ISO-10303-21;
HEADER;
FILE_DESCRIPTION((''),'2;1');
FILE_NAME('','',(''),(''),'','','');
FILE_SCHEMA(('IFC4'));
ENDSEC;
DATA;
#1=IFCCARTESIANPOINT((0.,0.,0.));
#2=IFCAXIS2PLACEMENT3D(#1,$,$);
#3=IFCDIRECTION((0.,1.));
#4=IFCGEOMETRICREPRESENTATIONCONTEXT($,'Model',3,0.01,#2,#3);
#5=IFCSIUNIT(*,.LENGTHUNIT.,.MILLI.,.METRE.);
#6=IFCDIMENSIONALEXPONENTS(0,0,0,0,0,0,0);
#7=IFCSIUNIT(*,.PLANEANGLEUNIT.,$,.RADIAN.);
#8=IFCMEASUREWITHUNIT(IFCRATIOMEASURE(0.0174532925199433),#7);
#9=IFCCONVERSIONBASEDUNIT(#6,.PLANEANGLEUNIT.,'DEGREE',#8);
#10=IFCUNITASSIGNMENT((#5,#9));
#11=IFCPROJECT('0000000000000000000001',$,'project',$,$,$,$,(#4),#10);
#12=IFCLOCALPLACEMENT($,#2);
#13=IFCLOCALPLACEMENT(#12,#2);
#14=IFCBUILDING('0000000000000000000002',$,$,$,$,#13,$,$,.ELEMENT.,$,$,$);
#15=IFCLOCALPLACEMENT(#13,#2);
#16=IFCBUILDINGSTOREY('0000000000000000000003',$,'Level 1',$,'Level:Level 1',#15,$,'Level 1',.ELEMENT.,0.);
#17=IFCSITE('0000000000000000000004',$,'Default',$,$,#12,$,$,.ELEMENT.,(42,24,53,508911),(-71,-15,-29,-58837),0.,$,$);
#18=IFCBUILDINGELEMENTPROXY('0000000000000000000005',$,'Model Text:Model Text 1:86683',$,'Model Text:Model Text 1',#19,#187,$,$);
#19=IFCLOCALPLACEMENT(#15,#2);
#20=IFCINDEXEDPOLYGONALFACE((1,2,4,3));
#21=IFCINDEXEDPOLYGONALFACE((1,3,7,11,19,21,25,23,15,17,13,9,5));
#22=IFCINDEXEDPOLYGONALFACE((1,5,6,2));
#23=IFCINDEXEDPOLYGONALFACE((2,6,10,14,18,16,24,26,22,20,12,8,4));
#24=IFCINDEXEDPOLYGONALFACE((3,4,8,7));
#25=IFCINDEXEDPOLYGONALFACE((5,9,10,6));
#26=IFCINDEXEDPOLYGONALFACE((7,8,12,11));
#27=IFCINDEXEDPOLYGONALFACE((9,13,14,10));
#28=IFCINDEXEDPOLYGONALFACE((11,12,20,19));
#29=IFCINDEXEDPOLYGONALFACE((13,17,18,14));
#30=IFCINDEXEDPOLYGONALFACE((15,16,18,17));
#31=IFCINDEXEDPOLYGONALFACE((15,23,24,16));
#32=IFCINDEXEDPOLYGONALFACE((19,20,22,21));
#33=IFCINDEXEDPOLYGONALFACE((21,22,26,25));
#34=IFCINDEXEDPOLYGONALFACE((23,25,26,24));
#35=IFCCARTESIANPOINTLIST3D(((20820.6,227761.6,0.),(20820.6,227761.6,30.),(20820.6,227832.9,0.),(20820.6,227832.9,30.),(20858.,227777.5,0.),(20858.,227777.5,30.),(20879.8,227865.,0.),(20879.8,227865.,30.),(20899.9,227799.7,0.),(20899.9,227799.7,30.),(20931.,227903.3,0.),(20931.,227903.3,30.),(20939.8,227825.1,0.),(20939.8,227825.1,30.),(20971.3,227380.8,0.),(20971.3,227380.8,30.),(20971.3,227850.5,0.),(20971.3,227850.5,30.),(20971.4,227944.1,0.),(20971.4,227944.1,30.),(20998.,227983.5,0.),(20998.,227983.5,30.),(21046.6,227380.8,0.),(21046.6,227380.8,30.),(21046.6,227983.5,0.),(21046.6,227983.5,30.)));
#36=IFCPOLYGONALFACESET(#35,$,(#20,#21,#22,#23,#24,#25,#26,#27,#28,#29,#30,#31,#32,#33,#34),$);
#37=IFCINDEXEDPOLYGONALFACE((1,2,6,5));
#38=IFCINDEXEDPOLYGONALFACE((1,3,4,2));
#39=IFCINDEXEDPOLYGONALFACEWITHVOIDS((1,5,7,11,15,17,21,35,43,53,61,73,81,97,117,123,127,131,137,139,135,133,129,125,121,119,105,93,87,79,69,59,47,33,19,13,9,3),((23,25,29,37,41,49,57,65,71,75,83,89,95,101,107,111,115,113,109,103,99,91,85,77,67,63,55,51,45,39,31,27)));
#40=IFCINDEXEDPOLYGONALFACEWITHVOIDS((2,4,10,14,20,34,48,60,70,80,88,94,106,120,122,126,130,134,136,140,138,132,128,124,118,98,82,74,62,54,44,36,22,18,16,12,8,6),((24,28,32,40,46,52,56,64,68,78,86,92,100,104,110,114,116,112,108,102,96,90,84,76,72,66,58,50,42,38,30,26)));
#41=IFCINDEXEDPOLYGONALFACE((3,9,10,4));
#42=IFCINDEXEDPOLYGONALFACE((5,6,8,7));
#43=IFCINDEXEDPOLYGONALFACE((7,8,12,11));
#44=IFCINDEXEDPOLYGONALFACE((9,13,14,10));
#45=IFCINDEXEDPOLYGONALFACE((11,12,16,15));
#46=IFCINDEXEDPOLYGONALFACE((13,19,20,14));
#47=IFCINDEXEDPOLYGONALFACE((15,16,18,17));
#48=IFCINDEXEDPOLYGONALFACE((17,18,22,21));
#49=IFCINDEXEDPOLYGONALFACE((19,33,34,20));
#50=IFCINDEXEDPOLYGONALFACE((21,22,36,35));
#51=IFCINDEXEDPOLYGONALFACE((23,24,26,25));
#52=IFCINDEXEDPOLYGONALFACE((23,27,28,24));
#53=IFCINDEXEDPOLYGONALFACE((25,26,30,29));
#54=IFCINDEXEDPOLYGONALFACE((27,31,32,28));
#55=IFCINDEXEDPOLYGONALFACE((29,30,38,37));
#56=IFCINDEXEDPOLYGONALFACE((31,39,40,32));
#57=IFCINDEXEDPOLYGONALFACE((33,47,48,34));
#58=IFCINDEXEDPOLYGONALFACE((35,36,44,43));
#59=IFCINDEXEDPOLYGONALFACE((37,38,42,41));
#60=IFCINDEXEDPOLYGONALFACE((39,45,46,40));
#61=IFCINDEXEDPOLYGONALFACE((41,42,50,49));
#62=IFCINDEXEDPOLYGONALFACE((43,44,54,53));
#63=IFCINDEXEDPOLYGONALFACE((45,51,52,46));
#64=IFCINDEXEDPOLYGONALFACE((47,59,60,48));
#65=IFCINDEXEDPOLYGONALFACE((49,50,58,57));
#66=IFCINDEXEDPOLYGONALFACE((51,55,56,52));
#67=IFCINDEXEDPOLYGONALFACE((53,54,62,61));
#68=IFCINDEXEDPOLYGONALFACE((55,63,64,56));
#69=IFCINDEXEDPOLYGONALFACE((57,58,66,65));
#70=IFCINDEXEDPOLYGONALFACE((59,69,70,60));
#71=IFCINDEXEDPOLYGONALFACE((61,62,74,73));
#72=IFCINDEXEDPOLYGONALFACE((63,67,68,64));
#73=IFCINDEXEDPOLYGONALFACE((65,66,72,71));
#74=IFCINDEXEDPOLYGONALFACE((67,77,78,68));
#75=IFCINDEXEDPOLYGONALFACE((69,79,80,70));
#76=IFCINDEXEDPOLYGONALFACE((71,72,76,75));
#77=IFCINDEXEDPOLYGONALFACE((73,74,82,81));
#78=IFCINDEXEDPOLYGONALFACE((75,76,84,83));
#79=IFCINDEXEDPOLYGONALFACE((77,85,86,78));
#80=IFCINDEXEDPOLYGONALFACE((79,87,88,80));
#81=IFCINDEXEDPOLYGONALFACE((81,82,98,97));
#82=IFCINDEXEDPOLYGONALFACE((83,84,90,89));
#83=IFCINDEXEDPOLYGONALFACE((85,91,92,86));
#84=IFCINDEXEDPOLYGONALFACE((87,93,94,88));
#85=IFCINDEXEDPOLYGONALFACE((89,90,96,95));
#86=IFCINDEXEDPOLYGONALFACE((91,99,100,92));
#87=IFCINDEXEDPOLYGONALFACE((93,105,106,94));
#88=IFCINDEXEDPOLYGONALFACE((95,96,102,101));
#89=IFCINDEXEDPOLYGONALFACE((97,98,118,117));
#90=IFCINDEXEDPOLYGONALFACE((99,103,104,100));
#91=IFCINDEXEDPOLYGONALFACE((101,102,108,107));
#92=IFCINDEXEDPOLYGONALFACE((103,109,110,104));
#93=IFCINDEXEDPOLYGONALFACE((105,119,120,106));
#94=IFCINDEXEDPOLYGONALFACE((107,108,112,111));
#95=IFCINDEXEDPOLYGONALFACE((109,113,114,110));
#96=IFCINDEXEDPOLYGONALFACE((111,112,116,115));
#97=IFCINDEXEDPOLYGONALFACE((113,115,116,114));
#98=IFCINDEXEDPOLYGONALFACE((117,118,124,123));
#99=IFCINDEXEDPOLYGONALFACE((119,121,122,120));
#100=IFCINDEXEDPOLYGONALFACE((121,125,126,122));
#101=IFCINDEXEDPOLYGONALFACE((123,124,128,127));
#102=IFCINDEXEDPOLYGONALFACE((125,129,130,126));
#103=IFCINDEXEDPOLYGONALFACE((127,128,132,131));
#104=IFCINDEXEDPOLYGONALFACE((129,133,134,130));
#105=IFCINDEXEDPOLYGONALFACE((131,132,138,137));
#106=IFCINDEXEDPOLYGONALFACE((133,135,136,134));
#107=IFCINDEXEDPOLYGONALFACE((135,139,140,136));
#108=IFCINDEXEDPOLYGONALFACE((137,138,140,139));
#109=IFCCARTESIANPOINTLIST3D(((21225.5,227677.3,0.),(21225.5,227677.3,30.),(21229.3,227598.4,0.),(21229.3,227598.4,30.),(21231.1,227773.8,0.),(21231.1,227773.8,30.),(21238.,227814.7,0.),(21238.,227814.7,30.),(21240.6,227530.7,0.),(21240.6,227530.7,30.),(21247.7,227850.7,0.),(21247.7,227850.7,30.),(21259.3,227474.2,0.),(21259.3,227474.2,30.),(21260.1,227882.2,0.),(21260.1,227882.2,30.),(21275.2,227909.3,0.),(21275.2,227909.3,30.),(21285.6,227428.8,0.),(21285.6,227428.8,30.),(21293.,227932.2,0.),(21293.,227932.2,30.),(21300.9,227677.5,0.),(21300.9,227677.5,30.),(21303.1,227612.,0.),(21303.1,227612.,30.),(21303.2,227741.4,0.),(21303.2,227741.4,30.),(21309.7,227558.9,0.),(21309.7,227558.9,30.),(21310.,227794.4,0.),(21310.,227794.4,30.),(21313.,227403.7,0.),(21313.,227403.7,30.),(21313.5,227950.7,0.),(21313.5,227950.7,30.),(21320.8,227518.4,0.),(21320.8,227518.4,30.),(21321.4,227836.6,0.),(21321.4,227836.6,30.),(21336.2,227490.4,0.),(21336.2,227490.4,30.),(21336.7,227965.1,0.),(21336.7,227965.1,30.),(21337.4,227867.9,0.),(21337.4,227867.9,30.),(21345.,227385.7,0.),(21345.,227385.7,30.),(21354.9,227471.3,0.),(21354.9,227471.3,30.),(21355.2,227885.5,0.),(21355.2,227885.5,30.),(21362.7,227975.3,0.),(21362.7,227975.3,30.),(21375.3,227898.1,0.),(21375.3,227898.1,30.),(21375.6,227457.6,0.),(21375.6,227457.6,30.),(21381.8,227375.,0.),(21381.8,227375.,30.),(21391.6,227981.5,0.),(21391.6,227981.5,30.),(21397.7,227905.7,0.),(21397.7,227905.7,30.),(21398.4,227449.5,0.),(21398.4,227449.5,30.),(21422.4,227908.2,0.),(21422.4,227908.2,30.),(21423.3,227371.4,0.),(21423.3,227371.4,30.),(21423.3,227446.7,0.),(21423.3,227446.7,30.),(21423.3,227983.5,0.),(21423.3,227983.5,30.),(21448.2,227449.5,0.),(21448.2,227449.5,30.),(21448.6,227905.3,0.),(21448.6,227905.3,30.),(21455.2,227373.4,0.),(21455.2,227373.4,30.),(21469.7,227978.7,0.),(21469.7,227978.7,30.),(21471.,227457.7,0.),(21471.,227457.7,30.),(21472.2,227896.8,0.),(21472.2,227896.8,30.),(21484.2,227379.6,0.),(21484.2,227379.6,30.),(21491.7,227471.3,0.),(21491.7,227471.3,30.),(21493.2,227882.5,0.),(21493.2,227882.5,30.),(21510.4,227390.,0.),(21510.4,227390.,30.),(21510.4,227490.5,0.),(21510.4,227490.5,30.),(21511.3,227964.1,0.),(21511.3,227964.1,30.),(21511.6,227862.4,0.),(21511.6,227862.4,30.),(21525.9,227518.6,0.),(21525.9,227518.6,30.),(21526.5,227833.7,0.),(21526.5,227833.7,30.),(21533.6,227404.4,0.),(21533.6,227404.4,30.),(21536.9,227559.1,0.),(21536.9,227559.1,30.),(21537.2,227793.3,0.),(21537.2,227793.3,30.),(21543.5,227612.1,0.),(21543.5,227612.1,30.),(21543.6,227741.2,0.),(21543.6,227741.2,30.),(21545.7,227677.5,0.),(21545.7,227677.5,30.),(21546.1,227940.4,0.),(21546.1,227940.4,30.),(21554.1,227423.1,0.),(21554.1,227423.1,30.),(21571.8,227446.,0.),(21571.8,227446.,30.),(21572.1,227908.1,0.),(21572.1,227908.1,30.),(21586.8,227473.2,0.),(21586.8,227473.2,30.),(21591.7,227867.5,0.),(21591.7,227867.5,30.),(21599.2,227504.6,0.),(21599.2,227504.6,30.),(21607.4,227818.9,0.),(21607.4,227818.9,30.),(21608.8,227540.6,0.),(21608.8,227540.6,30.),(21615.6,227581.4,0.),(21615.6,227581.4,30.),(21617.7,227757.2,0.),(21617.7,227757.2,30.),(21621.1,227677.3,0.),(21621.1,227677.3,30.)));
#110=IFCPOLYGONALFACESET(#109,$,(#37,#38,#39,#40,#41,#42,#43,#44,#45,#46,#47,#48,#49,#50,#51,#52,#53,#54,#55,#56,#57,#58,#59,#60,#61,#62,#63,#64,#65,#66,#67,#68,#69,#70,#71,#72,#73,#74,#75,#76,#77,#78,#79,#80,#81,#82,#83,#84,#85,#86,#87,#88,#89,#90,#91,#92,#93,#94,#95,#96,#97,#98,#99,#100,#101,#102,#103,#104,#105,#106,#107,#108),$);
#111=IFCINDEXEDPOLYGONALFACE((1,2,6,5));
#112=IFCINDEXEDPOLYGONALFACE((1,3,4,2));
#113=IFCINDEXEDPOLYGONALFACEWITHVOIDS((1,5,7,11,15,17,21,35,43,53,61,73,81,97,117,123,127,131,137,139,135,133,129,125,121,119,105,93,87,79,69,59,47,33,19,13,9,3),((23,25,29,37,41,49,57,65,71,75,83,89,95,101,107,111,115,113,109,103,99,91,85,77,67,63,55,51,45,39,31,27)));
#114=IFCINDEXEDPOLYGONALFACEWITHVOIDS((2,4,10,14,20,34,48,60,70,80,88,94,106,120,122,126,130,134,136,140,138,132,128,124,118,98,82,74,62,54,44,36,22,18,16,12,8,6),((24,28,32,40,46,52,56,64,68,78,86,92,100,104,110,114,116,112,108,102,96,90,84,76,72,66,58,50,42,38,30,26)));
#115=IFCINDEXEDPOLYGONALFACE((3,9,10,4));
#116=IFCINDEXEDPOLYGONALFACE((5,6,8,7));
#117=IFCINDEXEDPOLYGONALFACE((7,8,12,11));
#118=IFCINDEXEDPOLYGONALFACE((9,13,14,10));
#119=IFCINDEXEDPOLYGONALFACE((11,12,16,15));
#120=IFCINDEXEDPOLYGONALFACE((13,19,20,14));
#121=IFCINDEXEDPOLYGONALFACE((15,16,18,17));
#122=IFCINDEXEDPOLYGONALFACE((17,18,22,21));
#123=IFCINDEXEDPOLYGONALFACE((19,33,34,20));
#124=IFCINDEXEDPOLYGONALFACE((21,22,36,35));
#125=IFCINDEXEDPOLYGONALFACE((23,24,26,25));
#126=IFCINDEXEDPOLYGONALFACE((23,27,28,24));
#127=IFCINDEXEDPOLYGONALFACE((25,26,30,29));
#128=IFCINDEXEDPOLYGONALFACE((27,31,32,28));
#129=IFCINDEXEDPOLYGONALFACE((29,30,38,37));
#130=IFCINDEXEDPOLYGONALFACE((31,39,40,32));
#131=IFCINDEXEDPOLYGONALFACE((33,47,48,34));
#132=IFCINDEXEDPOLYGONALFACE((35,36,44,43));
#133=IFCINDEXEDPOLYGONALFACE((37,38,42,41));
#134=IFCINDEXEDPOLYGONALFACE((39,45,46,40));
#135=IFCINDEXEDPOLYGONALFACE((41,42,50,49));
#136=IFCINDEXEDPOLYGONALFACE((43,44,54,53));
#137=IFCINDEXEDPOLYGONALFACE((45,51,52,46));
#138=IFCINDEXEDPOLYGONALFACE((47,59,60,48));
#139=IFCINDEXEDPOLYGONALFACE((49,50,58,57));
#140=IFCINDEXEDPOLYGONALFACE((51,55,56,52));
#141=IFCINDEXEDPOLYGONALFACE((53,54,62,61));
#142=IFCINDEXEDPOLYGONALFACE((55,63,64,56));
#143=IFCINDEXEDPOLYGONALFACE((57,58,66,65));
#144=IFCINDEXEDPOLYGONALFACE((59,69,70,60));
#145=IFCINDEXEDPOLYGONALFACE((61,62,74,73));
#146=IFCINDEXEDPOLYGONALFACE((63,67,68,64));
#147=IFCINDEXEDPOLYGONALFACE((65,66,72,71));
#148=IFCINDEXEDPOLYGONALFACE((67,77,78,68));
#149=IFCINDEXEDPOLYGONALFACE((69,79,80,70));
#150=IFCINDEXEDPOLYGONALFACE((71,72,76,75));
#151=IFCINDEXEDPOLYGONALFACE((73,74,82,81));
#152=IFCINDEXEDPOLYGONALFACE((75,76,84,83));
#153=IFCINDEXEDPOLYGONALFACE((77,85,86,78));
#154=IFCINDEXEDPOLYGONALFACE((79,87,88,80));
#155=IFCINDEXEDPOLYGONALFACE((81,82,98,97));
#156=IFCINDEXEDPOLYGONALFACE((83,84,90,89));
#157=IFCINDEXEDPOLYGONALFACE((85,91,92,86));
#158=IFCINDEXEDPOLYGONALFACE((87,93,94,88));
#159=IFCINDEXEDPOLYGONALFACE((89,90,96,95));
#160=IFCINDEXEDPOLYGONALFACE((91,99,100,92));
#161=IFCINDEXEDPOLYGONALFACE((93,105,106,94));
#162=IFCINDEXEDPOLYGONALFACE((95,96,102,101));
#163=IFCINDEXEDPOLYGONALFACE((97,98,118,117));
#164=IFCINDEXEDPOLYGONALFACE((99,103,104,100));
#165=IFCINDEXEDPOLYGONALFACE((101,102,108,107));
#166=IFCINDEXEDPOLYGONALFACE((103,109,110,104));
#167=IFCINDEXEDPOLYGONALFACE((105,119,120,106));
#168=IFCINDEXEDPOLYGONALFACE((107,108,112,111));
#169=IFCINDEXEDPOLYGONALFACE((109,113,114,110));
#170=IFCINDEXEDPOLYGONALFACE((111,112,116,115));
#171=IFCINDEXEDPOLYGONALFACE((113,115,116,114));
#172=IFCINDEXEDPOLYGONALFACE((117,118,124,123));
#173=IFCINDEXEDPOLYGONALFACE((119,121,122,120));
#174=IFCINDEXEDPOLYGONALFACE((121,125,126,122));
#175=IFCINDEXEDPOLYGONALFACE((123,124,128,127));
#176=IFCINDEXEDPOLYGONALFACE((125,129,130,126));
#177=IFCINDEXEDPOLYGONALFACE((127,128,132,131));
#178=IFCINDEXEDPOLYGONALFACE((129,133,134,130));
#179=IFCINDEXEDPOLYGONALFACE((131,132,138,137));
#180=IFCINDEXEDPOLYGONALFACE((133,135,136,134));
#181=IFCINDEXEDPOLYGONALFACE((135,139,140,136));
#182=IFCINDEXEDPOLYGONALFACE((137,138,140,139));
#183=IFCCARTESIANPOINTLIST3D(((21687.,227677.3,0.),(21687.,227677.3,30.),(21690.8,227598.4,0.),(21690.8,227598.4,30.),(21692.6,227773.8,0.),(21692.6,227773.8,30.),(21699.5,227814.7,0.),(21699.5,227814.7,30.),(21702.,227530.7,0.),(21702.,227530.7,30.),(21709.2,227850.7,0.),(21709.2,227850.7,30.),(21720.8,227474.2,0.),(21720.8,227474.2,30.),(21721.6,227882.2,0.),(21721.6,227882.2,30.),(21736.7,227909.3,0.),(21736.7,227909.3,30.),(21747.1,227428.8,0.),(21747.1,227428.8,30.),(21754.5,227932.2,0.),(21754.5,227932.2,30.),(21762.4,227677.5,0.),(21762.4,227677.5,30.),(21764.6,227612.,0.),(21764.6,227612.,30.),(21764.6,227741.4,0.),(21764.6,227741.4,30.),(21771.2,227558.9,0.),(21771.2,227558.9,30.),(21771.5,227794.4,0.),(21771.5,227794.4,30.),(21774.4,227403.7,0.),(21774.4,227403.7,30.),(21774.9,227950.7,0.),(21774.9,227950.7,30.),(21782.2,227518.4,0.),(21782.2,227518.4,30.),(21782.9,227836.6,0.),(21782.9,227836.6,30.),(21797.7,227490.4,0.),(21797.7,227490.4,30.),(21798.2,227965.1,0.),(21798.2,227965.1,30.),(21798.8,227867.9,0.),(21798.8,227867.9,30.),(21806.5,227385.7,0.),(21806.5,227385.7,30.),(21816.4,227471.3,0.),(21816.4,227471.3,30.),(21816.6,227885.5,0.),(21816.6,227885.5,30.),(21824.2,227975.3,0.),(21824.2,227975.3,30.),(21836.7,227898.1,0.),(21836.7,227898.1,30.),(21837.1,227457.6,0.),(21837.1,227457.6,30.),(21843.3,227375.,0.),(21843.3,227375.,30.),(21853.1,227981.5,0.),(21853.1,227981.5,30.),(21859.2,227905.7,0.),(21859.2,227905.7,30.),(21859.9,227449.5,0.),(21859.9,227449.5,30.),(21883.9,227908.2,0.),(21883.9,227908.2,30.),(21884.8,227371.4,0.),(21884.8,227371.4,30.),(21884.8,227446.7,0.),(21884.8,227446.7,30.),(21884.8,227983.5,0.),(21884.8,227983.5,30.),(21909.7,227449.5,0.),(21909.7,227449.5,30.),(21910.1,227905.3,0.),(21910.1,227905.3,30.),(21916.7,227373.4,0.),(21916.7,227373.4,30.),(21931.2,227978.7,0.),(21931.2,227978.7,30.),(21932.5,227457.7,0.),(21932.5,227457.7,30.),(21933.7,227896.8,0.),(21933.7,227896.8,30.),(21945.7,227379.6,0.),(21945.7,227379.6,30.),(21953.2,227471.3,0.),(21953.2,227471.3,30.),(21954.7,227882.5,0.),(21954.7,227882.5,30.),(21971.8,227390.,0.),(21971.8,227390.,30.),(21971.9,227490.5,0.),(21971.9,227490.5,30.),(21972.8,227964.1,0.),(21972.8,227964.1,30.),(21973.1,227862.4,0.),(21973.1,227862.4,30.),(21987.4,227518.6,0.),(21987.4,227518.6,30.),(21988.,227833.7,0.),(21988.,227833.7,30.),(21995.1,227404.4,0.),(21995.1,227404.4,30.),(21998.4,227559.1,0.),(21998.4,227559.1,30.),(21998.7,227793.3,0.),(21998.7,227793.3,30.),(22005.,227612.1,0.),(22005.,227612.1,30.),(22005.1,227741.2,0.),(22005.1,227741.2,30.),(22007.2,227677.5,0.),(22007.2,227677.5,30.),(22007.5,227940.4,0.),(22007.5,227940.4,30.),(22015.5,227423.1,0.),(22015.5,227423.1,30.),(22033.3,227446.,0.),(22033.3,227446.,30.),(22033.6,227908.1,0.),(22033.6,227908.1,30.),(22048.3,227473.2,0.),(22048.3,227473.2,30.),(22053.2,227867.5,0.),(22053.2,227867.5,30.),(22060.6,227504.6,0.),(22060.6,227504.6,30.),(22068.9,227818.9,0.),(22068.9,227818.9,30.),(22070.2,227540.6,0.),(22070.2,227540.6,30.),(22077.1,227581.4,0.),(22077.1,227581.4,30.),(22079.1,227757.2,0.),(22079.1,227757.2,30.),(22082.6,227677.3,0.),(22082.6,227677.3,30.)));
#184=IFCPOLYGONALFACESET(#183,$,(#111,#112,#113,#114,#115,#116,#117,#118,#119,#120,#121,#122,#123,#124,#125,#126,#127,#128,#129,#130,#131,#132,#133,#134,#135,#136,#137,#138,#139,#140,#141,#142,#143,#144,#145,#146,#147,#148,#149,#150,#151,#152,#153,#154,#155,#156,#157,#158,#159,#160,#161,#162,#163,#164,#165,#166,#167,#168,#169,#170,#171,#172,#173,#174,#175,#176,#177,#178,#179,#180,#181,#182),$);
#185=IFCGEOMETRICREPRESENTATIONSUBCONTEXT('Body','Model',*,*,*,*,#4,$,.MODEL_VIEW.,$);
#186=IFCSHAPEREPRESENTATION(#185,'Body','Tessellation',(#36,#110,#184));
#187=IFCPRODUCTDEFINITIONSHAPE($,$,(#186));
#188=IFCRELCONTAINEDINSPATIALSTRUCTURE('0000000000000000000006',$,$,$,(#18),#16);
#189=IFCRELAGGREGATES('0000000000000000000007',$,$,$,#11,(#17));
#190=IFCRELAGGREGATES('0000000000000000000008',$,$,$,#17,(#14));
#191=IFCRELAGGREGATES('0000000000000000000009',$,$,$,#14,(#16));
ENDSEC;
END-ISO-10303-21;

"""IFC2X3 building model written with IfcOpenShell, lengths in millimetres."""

from ifc_helpers import new_model, entity, si_unit, converted_unit, direction, frame, origin, place, context, subcontext, project, spatial, polyline, outline, extrude, element, save


model = new_model("IFC2X3")

# Units and contexts
model_context = context("Model", 3, precision=0.01, world=origin(), true_north=direction((0.0, 1.0)))
body_context = subcontext(model_context, "Body", "Model", "MODEL_VIEW")
ifc_project = project(units=[si_unit("LENGTHUNIT", "METRE", prefix="MILLI"), converted_unit("PLANEANGLEUNIT", "DEGREE", entity("IfcRatioMeasure", 0.0174532925199433), si_unit("PLANEANGLEUNIT", "RADIAN"), dimensions=[0, 0, 0, 0, 0, 0, 0])], contexts=[model_context])

# Site, building, storey
site_placement = place(None, origin())
site = spatial("IfcSite", under=ifc_project, at=site_placement, Name="Default", CompositionType="ELEMENT", RefLatitude=(42, 24, 53, 508911), RefLongitude=(-71, -15, -29, -58837), RefElevation=0.0)
building_placement = place(site_placement, origin())
building = spatial("IfcBuilding", under=site, at=building_placement, CompositionType="ELEMENT")
storey_placement = place(building_placement, origin())
storey = spatial("IfcBuildingStorey", under=building, at=storey_placement, Name="Level 1", ObjectType="Level:Level 1", LongName="Level 1", CompositionType="ELEMENT", Elevation=0.0)

# Building element proxy
proxy_1_placement = place(storey_placement, origin())
element("IfcBuildingElementProxy", 1, at=proxy_1_placement, inside=storey, Name="Model Text:Model Text 1:86683", ObjectType="Model Text:Model Text 1", context=body_context, shape_type="SweptSolid", body=[
    extrude(outline(polyline([(-410.6, -111.6), (192.1, -111.6), (192.1, -63.1), (152.7, -36.4), (111.9, 4.0), (73.6, 55.2), (41.4, 114.4), (-29.8, 114.4), (-13.9, 77.0), (8.3, 35.1), (33.7, -4.8), (59.1, -36.3), (-410.6, -36.3), (-410.6, -111.6)])), frame((20935.0, 227791.4, 0.0), z_axis=(0.0, 0.0, 1.0), x_axis=(0.0, 1.0, 0.0)), (0.0, 0.0, 1.0), 30.0),
    extrude(outline(polyline([(-10.6, -198.7), (68.3, -198.7), (136.5, -190.7), (193.9, -174.7), (240.5, -150.6), (266.9, -124.4), (286.3, -93.2), (298.8, -57.0), (304.3, -15.7), (303.8, 16.2), (299.0, 45.5), (289.9, 72.1), (276.6, 96.0), (258.9, 117.3), (236.9, 136.2), (210.4, 152.5), (179.6, 166.3), (144.1, 177.6), (103.7, 186.3), (8.2, 196.4), (-71.8, 196.7), (-134.0, 189.4), (-183.3, 176.1), (-224.7, 158.4), (-258.2, 133.9), (-283.5, 100.3), (-300.1, 59.5), (-307.1, 13.4), (-306.6, -18.4), (-301.8, -47.5), (-292.8, -74.0), (-279.6, -97.9), (-262.0, -119.2), (-240.0, -138.1), (-213.6, -154.5), (-182.8, -168.4), (-147.3, -179.8), (-106.7, -188.6), (-10.6, -198.7)]), holes=[polyline([(-7.2, -123.5), (-71.0, -118.2), (-123.6, -108.8), (-165.2, -95.4), (-195.7, -78.0), (-212.4, -59.4), (-224.1, -38.7), (-230.6, -15.9), (-231.9, 8.9), (-227.8, 35.0), (-218.1, 58.1), (-202.8, 78.4), (-182.0, 95.8), (-152.6, 109.4), (-111.7, 118.1), (-59.4, 122.0), (4.4, 121.1), (69.6, 115.8), (122.2, 106.7), (162.2, 93.7), (189.5, 77.0), (207.7, 57.4), (220.4, 36.0), (227.5, 12.8), (229.1, -12.1), (225.2, -36.8), (215.9, -59.2), (201.3, -79.3), (181.4, -97.1), (152.6, -111.2), (111.6, -120.3), (58.3, -124.4), (-7.2, -123.5)])]), frame((21424.6, 227676.1, 0.0), z_axis=(0.0, 0.0, 1.0), x_axis=(0.047515, -0.998871, 0.0)), (0.0, 0.0, 1.0), 30.0),
    extrude(outline(polyline([(-10.6, -198.7), (68.3, -198.7), (136.5, -190.7), (193.9, -174.7), (240.5, -150.6), (266.9, -124.4), (286.3, -93.2), (298.8, -57.0), (304.3, -15.7), (303.8, 16.2), (299.0, 45.5), (289.9, 72.1), (276.6, 96.0), (258.9, 117.3), (236.9, 136.2), (210.4, 152.5), (179.6, 166.3), (144.1, 177.6), (103.7, 186.3), (8.2, 196.4), (-71.8, 196.7), (-134.0, 189.4), (-183.3, 176.1), (-224.7, 158.4), (-258.2, 133.9), (-283.5, 100.3), (-300.1, 59.5), (-307.1, 13.4), (-306.6, -18.4), (-301.8, -47.5), (-292.8, -74.0), (-279.6, -97.9), (-262.0, -119.2), (-240.0, -138.1), (-213.6, -154.5), (-182.8, -168.4), (-147.3, -179.8), (-106.7, -188.6), (-10.6, -198.7)]), holes=[polyline([(-7.2, -123.5), (-71.0, -118.2), (-123.6, -108.8), (-165.2, -95.4), (-195.7, -78.0), (-212.4, -59.4), (-224.1, -38.7), (-230.6, -15.9), (-231.9, 8.9), (-227.8, 35.0), (-218.1, 58.1), (-202.8, 78.4), (-182.0, 95.8), (-152.6, 109.4), (-111.7, 118.1), (-59.4, 122.0), (4.4, 121.1), (69.6, 115.8), (122.2, 106.7), (162.2, 93.7), (189.5, 77.0), (207.7, 57.4), (220.4, 36.0), (227.5, 12.8), (229.1, -12.1), (225.2, -36.8), (215.9, -59.2), (201.3, -79.3), (181.4, -97.1), (152.6, -111.2), (111.6, -120.3), (58.3, -124.4), (-7.2, -123.5)])]), frame((21886.0, 227676.1, 0.0), z_axis=(0.0, 0.0, 1.0), x_axis=(0.047515, -0.998871, 0.0)), (0.0, 0.0, 1.0), 30.0),
])

save(model, "model.ifc")
